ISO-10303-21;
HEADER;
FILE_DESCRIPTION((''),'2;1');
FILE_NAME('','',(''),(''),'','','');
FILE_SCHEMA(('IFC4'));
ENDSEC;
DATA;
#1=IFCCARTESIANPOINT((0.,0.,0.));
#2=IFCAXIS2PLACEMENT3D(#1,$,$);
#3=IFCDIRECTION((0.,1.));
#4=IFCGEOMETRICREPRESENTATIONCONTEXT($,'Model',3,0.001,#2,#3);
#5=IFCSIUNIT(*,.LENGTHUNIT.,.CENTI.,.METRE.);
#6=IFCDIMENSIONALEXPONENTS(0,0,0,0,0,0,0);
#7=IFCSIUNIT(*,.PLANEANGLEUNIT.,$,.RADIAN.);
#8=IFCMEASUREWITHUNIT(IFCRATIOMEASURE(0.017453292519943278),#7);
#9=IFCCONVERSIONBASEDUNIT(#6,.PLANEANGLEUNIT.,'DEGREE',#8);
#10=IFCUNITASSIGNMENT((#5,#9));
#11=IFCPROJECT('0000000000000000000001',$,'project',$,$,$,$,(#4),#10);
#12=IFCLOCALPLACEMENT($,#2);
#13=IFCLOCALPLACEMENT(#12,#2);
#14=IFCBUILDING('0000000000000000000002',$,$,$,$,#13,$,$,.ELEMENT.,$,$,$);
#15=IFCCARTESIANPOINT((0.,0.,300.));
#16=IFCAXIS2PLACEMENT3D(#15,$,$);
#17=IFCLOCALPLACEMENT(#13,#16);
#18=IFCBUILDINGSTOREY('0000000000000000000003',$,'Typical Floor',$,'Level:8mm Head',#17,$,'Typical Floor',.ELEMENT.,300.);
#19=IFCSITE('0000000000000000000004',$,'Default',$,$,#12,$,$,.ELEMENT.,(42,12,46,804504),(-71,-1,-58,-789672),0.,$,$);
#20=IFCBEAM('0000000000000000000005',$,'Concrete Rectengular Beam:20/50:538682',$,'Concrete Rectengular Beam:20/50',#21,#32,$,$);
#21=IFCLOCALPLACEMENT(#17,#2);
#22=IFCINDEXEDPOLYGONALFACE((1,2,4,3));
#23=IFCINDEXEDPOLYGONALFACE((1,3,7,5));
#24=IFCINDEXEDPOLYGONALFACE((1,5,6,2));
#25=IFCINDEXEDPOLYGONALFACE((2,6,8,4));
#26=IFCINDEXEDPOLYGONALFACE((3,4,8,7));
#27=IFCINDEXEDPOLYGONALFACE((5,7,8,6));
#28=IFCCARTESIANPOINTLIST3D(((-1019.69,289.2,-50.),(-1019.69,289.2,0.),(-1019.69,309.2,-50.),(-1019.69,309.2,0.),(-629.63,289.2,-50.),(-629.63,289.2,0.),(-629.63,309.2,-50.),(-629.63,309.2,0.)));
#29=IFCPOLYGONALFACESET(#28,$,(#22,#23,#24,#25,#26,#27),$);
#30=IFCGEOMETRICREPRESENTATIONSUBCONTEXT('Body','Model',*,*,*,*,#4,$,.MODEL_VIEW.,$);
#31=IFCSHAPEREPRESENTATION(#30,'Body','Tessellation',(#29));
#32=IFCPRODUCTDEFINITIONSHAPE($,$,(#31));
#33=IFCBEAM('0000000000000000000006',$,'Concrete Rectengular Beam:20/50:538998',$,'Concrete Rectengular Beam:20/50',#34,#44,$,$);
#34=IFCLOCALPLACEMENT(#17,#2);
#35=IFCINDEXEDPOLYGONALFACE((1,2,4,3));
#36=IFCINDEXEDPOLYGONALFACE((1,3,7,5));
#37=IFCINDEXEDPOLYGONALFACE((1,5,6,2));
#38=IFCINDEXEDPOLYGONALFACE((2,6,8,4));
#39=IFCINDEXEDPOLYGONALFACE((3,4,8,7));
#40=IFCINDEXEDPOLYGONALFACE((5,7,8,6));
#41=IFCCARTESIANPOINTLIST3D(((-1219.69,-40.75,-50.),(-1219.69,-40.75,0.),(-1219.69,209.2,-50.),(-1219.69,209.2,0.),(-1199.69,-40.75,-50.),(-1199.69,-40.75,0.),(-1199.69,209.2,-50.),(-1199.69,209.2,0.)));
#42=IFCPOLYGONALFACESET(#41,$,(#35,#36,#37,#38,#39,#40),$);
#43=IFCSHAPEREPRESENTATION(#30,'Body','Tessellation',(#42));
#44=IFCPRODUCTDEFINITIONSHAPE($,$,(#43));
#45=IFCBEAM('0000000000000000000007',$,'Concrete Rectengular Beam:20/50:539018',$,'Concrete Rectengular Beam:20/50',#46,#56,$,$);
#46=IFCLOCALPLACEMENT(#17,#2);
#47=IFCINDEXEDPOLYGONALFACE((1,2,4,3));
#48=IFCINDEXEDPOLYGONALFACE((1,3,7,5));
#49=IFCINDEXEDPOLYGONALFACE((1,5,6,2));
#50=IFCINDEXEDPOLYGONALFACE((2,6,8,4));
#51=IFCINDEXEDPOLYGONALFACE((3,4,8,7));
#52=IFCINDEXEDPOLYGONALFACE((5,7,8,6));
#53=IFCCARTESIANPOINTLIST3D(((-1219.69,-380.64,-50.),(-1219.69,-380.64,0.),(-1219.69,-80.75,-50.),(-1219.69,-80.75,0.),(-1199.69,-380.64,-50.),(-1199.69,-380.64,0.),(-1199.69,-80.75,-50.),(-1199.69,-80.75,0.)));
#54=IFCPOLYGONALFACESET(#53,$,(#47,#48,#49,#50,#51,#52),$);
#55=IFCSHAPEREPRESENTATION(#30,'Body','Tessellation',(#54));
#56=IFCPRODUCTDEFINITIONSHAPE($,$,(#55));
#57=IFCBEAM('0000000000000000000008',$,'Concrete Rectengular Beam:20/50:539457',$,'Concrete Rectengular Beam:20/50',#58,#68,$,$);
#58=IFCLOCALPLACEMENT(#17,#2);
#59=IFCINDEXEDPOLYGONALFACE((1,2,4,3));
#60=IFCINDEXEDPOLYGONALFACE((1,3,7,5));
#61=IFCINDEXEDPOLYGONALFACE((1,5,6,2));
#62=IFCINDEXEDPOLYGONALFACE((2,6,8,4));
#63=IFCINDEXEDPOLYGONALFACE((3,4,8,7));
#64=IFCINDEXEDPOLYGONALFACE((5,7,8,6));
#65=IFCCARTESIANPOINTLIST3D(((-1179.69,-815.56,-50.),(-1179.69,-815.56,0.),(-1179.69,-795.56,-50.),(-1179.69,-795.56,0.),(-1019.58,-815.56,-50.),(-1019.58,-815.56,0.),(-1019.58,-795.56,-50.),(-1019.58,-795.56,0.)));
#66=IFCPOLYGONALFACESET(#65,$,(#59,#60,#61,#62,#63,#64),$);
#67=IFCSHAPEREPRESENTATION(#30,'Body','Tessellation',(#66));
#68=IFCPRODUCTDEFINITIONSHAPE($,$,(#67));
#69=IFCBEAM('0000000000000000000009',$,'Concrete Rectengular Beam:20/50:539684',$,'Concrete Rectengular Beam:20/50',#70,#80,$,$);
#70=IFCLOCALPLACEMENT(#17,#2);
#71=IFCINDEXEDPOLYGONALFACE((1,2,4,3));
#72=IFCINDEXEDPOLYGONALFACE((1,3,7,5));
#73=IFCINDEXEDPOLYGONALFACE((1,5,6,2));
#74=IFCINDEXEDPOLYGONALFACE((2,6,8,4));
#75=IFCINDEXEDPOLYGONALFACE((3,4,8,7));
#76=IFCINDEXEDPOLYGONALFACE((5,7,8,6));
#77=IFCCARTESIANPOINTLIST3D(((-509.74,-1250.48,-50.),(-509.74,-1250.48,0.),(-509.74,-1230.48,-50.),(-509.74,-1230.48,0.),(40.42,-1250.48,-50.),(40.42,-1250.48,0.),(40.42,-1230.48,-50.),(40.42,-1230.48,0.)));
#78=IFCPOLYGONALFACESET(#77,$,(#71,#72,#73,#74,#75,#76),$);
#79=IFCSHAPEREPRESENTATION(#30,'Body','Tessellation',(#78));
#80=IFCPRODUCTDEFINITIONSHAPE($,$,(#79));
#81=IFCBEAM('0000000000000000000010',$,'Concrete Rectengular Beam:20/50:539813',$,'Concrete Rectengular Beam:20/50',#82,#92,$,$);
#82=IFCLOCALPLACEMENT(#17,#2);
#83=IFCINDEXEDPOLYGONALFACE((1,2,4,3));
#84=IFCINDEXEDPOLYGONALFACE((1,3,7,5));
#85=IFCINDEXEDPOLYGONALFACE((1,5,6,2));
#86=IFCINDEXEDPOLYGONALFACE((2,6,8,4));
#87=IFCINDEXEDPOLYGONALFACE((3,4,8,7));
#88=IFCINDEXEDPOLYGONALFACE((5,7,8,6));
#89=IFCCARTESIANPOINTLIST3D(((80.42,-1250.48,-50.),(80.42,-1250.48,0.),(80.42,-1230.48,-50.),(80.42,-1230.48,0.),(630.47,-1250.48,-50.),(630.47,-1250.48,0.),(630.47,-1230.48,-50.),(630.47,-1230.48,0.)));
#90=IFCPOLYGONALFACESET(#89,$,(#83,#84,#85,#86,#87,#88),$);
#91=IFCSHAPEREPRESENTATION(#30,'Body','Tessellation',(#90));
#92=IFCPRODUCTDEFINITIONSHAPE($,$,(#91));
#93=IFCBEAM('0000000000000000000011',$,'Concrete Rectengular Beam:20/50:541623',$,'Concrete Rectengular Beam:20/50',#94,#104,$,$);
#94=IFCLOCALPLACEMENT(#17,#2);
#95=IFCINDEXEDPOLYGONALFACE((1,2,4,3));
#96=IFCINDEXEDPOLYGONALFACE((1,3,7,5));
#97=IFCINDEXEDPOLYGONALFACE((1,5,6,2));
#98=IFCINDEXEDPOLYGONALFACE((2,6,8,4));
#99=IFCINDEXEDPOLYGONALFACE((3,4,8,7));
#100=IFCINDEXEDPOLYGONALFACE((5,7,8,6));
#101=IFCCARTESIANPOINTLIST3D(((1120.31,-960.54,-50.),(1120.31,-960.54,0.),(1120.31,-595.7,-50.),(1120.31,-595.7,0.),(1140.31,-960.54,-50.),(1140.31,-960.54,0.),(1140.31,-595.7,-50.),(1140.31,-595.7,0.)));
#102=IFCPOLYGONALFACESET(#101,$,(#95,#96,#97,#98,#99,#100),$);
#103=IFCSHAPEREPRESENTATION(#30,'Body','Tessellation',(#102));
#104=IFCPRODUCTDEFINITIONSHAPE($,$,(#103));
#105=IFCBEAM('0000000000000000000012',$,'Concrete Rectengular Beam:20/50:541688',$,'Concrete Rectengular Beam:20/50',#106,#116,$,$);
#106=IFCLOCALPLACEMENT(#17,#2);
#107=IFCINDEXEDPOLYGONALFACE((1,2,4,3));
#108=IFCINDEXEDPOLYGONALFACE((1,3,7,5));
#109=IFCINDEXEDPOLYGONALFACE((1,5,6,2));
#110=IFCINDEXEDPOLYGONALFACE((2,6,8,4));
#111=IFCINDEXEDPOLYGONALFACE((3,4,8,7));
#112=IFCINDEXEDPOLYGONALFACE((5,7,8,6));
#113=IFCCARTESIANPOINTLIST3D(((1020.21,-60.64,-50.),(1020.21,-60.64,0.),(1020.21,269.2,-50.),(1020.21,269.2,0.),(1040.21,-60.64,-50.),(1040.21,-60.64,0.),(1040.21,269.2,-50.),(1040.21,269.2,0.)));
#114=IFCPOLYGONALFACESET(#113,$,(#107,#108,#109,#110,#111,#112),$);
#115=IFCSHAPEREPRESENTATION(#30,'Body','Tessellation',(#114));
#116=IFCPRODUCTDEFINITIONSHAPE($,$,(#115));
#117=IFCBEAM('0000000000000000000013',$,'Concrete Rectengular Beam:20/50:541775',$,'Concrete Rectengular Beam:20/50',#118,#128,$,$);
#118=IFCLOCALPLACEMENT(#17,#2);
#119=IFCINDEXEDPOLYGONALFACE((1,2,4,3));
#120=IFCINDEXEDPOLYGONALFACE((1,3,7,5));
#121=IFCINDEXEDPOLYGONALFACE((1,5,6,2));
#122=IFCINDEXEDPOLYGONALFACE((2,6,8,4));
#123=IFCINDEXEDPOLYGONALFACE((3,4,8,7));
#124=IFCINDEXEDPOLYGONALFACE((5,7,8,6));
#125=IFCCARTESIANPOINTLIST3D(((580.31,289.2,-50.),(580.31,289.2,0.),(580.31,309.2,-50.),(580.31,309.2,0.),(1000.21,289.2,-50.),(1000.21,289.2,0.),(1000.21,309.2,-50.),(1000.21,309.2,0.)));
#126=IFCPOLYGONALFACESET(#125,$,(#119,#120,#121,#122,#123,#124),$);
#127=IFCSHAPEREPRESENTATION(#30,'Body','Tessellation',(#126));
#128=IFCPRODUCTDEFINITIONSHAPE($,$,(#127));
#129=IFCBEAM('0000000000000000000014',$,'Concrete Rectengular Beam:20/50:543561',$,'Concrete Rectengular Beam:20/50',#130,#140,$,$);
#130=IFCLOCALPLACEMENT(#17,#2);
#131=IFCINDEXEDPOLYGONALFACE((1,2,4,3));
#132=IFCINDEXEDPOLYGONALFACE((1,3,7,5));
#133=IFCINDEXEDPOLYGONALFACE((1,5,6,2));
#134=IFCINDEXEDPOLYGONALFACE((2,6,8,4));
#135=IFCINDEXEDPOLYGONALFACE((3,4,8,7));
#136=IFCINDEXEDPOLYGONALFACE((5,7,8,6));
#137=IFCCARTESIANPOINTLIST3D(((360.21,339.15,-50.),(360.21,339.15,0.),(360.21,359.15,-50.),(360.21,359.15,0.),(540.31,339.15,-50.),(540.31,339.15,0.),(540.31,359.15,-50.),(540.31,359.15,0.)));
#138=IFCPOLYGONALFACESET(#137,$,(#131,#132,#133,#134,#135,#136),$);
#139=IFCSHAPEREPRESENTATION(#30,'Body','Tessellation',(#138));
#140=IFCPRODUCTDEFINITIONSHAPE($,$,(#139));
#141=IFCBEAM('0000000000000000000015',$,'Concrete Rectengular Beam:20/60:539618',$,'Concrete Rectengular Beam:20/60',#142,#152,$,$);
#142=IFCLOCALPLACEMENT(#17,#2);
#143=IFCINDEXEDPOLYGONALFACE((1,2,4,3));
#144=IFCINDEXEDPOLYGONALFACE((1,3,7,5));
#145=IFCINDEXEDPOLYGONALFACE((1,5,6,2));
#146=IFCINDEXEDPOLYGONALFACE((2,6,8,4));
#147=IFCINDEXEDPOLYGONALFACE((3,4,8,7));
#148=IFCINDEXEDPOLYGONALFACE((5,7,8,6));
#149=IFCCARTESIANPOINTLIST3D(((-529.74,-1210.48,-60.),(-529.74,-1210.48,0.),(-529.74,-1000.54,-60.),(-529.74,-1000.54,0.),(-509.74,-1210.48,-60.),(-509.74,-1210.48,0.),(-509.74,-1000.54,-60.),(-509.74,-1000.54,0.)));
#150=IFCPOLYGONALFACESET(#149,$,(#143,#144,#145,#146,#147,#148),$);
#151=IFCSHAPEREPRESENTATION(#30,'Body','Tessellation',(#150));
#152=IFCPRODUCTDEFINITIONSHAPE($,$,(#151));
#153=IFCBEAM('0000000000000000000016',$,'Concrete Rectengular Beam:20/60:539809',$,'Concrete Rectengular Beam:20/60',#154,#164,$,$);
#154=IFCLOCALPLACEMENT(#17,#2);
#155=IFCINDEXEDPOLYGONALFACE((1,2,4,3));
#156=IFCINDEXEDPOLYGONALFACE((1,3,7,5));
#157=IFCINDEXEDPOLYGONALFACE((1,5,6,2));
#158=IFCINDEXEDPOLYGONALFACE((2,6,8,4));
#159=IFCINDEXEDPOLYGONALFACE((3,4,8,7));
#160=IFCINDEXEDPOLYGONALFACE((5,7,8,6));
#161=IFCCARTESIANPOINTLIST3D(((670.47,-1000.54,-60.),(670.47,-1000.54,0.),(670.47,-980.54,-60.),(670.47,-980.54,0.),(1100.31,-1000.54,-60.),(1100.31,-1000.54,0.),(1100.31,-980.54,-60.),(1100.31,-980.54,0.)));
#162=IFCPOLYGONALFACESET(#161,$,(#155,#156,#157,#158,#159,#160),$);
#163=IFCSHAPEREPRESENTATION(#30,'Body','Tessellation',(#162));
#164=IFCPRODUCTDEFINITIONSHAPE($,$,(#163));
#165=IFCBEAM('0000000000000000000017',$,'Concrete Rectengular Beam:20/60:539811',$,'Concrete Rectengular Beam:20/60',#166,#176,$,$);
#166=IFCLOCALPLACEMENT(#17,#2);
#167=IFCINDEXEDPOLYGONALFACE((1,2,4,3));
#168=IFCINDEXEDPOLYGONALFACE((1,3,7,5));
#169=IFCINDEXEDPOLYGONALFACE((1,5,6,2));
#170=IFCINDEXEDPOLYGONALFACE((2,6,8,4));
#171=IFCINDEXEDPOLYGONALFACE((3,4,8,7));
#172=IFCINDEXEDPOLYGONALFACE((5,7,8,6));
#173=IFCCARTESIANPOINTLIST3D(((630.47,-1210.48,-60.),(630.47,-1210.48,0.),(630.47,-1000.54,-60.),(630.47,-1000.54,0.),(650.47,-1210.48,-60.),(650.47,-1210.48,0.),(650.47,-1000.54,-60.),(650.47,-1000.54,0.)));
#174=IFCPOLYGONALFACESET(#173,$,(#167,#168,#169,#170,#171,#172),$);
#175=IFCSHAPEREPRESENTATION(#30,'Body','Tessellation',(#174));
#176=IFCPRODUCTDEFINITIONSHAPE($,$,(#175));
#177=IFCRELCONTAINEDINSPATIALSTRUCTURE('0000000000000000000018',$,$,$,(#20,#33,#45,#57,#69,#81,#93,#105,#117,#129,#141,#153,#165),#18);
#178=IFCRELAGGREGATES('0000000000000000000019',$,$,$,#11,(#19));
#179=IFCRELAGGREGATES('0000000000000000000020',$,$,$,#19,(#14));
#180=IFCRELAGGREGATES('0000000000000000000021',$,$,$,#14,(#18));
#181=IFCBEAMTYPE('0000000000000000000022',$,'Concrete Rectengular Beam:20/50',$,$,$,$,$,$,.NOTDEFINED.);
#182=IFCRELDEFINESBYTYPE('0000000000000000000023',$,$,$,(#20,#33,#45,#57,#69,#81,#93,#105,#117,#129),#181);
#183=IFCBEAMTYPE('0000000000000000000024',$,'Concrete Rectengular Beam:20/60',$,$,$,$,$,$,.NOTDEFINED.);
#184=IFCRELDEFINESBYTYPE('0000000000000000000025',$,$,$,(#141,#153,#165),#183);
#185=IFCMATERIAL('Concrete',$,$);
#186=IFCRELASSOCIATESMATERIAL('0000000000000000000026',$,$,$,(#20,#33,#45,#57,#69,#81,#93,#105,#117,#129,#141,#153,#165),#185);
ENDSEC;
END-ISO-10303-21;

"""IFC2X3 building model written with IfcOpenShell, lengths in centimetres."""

from ifc_helpers import new_model, entity, si_unit, converted_unit, direction, frame, frame_2d, origin, origin_2d_with_axis, place, context, subcontext, project, spatial, rectangle, extrude, material, type_object, element, save


model = new_model("IFC2X3")

# Units and contexts
model_context = context("Model", 3, precision=0.001, world=origin(), true_north=direction((0.0, 1.0)))
body_context = subcontext(model_context, "Body", "Model", "MODEL_VIEW")
ifc_project = project(units=[si_unit("LENGTHUNIT", "METRE", prefix="CENTI"), converted_unit("PLANEANGLEUNIT", "DEGREE", entity("IfcRatioMeasure", 0.017453292519943278), si_unit("PLANEANGLEUNIT", "RADIAN"), dimensions=[0, 0, 0, 0, 0, 0, 0])], contexts=[model_context])

# Site, building, storey
site_placement = place(None, origin())
site = spatial("IfcSite", under=ifc_project, at=site_placement, Name="Default", CompositionType="ELEMENT", RefLatitude=(42, 12, 46, 804504), RefLongitude=(-71, -1, -58, -789672), RefElevation=0.0)
building_placement = place(site_placement, origin())
building = spatial("IfcBuilding", under=site, at=building_placement, CompositionType="ELEMENT")
storey_placement = place(building_placement, frame((0.0, 0.0, 300.0)))
storey = spatial("IfcBuildingStorey", under=building, at=storey_placement, Name="Typical Floor", ObjectType="Level:8mm Head", LongName="Typical Floor", CompositionType="ELEMENT", Elevation=300.0)

# Beams
ifc_material = material(Name="Concrete")
beam_type_1 = type_object("IfcBeamType", Name="Concrete Rectengular Beam:20/50", PredefinedType="NOTDEFINED")
beam_1_placement = place(storey_placement, frame((-619.63, 299.2, 0.0), z_axis=(0.0, 0.0, 1.0), x_axis=(-1.0, 0.0, 0.0)))
element("IfcBeam", 1, at=beam_1_placement, inside=storey, type_object=beam_type_1, material=ifc_material, Name="Concrete Rectengular Beam:20/50:538682", ObjectType="Concrete Rectengular Beam:20/50", context=body_context, shape_type="SweptSolid", body=[
    extrude(rectangle(XDim=50.0, YDim=20.0, at=frame_2d((0.0, 0.0), x_axis=(1.0, 0.0))), frame((10.0, 0.0, -25.0), z_axis=(1.0, 0.0, 0.0), x_axis=(0.0, 0.0, -1.0)), (0.0, 0.0, 1.0), 390.05),
])
beam_2_placement = place(storey_placement, frame((-1209.69, 229.2, 0.0), z_axis=(0.0, 0.0, 1.0), x_axis=(0.0, -1.0, 0.0)))
element("IfcBeam", 2, at=beam_2_placement, inside=storey, type_object=beam_type_1, material=ifc_material, Name="Concrete Rectengular Beam:20/50:538998", ObjectType="Concrete Rectengular Beam:20/50", context=body_context, shape_type="SweptSolid", body=[
    extrude(rectangle(XDim=50.0, YDim=20.0, at=frame_2d((0.0, 0.0), x_axis=(1.0, 0.0))), frame((20.0, 0.0, -25.0), z_axis=(1.0, 0.0, 0.0), x_axis=(0.0, 0.0, -1.0)), (0.0, 0.0, 1.0), 249.95),
])
beam_3_placement = place(storey_placement, frame((-1209.69, -60.75, 0.0), z_axis=(0.0, 0.0, 1.0), x_axis=(0.0, -1.0, 0.0)))
element("IfcBeam", 3, at=beam_3_placement, inside=storey, type_object=beam_type_1, material=ifc_material, Name="Concrete Rectengular Beam:20/50:539018", ObjectType="Concrete Rectengular Beam:20/50", context=body_context, shape_type="SweptSolid", body=[
    extrude(rectangle(XDim=50.0, YDim=20.0, at=frame_2d((0.0, 0.0), x_axis=(1.0, 0.0))), frame((20.0, 0.0, -25.0), z_axis=(1.0, 0.0, 0.0), x_axis=(0.0, 0.0, -1.0)), (0.0, 0.0, 1.0), 299.89),
])
beam_4_placement = place(storey_placement, frame((-1199.69, -805.56, 0.0)))
element("IfcBeam", 4, at=beam_4_placement, inside=storey, type_object=beam_type_1, material=ifc_material, Name="Concrete Rectengular Beam:20/50:539457", ObjectType="Concrete Rectengular Beam:20/50", context=body_context, shape_type="SweptSolid", body=[
    extrude(rectangle(XDim=50.0, YDim=20.0, at=frame_2d((0.0, 0.0), x_axis=(1.0, 0.0))), frame((20.0, 0.0, -25.0), z_axis=(1.0, 0.0, 0.0), x_axis=(0.0, 0.0, -1.0)), (0.0, 0.0, 1.0), 160.11),
])
beam_5_placement = place(storey_placement, frame((60.42, -1240.48, 0.0), z_axis=(0.0, 0.0, 1.0), x_axis=(-1.0, 0.0, 0.0)))
element("IfcBeam", 5, at=beam_5_placement, inside=storey, type_object=beam_type_1, material=ifc_material, Name="Concrete Rectengular Beam:20/50:539684", ObjectType="Concrete Rectengular Beam:20/50", context=body_context, shape_type="SweptSolid", body=[
    extrude(rectangle(XDim=50.0, YDim=20.0, at=frame_2d((0.0, 0.0), x_axis=(1.0, 0.0))), frame((20.0, 0.0, -25.0), z_axis=(1.0, 0.0, 0.0), x_axis=(0.0, 0.0, -1.0)), (0.0, 0.0, 1.0), 550.16),
])
beam_6_placement = place(storey_placement, frame((60.42, -1240.48, 0.0)))
element("IfcBeam", 6, at=beam_6_placement, inside=storey, type_object=beam_type_1, material=ifc_material, Name="Concrete Rectengular Beam:20/50:539813", ObjectType="Concrete Rectengular Beam:20/50", context=body_context, shape_type="SweptSolid", body=[
    extrude(rectangle(XDim=50.0, YDim=20.0, at=frame_2d((0.0, 0.0), x_axis=(1.0, 0.0))), frame((20.0, 0.0, -25.0), z_axis=(1.0, 0.0, 0.0), x_axis=(0.0, 0.0, -1.0)), (0.0, 0.0, 1.0), 550.05),
])
beam_7_placement = place(storey_placement, frame((1130.31, -980.54, 0.0), z_axis=(0.0, 0.0, 1.0), x_axis=(0.0, 1.0, 0.0)))
element("IfcBeam", 7, at=beam_7_placement, inside=storey, type_object=beam_type_1, material=ifc_material, Name="Concrete Rectengular Beam:20/50:541623", ObjectType="Concrete Rectengular Beam:20/50", context=body_context, shape_type="SweptSolid", body=[
    extrude(rectangle(XDim=50.0, YDim=20.0, at=frame_2d((0.0, 0.0), x_axis=(1.0, 0.0))), frame((20.0, 0.0, -25.0), z_axis=(1.0, 0.0, 0.0), x_axis=(0.0, 0.0, -1.0)), (0.0, 0.0, 1.0), 364.84),
])
beam_8_placement = place(storey_placement, frame((1030.21, -70.64, 0.0), z_axis=(0.0, 0.0, 1.0), x_axis=(0.0, 1.0, 0.0)))
element("IfcBeam", 8, at=beam_8_placement, inside=storey, type_object=beam_type_1, material=ifc_material, Name="Concrete Rectengular Beam:20/50:541688", ObjectType="Concrete Rectengular Beam:20/50", context=body_context, shape_type="SweptSolid", body=[
    extrude(rectangle(XDim=50.0, YDim=20.0, at=frame_2d((0.0, 0.0), x_axis=(1.0, 0.0))), frame((10.0, 0.0, -25.0), z_axis=(1.0, 0.0, 0.0), x_axis=(0.0, 0.0, -1.0)), (0.0, 0.0, 1.0), 329.84),
])
beam_9_placement = place(storey_placement, frame((1020.21, 299.2, 0.0), z_axis=(0.0, 0.0, 1.0), x_axis=(-1.0, 0.0, 0.0)))
element("IfcBeam", 9, at=beam_9_placement, inside=storey, type_object=beam_type_1, material=ifc_material, Name="Concrete Rectengular Beam:20/50:541775", ObjectType="Concrete Rectengular Beam:20/50", context=body_context, shape_type="SweptSolid", body=[
    extrude(rectangle(XDim=50.0, YDim=20.0, at=frame_2d((0.0, 0.0), x_axis=(1.0, 0.0))), frame((20.0, 0.0, -25.0), z_axis=(1.0, 0.0, 0.0), x_axis=(0.0, 0.0, -1.0)), (0.0, 0.0, 1.0), 419.89),
])
beam_10_placement = place(storey_placement, frame((550.31, 349.15, 0.0), z_axis=(0.0, 0.0, 1.0), x_axis=(-1.0, 0.0, 0.0)))
element("IfcBeam", 10, at=beam_10_placement, inside=storey, type_object=beam_type_1, material=ifc_material, Name="Concrete Rectengular Beam:20/50:543561", ObjectType="Concrete Rectengular Beam:20/50", context=body_context, shape_type="SweptSolid", body=[
    extrude(rectangle(XDim=50.0, YDim=20.0, at=frame_2d((0.0, 0.0), x_axis=(1.0, 0.0))), frame((10.0, 0.0, -25.0), z_axis=(1.0, 0.0, 0.0), x_axis=(0.0, 0.0, -1.0)), (0.0, 0.0, 1.0), 180.11),
])
beam_type_2 = type_object("IfcBeamType", Name="Concrete Rectengular Beam:20/60", PredefinedType="NOTDEFINED")
beam_11_placement = place(storey_placement, frame((-519.74, -980.54, 0.0), z_axis=(0.0, 0.0, 1.0), x_axis=(0.0, -1.0, 0.0)))
element("IfcBeam", 11, at=beam_11_placement, inside=storey, type_object=beam_type_2, material=ifc_material, Name="Concrete Rectengular Beam:20/60:539618", ObjectType="Concrete Rectengular Beam:20/60", context=body_context, shape_type="SweptSolid", body=[
    extrude(rectangle(XDim=60.0, YDim=20.0, at=origin_2d_with_axis()), frame((20.0, 0.0, -30.0), z_axis=(1.0, 0.0, 0.0), x_axis=(0.0, 0.0, -1.0)), (0.0, 0.0, 1.0), 209.95),
])
beam_12_placement = place(storey_placement, frame((1130.31, -990.54, 0.0), z_axis=(0.0, 0.0, 1.0), x_axis=(-1.0, 0.0, 0.0)))
element("IfcBeam", 12, at=beam_12_placement, inside=storey, type_object=beam_type_2, material=ifc_material, Name="Concrete Rectengular Beam:20/60:539809", ObjectType="Concrete Rectengular Beam:20/60", context=body_context, shape_type="SweptSolid", body=[
    extrude(rectangle(XDim=60.0, YDim=20.0, at=frame_2d((0.0, 0.0), x_axis=(1.0, 0.0))), frame((30.0, 0.0, -30.0), z_axis=(1.0, 0.0, 0.0), x_axis=(0.0, 0.0, -1.0)), (0.0, 0.0, 1.0), 429.84),
])
beam_13_placement = place(storey_placement, frame((640.47, -980.54, 0.0), z_axis=(0.0, 0.0, 1.0), x_axis=(0.0, -1.0, 0.0)))
element("IfcBeam", 13, at=beam_13_placement, inside=storey, type_object=beam_type_2, material=ifc_material, Name="Concrete Rectengular Beam:20/60:539811", ObjectType="Concrete Rectengular Beam:20/60", context=body_context, shape_type="SweptSolid", body=[
    extrude(rectangle(XDim=60.0, YDim=20.0, at=frame_2d((0.0, 0.0), x_axis=(1.0, 0.0))), frame((20.0, 0.0, -30.0), z_axis=(1.0, 0.0, 0.0), x_axis=(0.0, 0.0, -1.0)), (0.0, 0.0, 1.0), 209.95),
])

save(model, "model.ifc")
